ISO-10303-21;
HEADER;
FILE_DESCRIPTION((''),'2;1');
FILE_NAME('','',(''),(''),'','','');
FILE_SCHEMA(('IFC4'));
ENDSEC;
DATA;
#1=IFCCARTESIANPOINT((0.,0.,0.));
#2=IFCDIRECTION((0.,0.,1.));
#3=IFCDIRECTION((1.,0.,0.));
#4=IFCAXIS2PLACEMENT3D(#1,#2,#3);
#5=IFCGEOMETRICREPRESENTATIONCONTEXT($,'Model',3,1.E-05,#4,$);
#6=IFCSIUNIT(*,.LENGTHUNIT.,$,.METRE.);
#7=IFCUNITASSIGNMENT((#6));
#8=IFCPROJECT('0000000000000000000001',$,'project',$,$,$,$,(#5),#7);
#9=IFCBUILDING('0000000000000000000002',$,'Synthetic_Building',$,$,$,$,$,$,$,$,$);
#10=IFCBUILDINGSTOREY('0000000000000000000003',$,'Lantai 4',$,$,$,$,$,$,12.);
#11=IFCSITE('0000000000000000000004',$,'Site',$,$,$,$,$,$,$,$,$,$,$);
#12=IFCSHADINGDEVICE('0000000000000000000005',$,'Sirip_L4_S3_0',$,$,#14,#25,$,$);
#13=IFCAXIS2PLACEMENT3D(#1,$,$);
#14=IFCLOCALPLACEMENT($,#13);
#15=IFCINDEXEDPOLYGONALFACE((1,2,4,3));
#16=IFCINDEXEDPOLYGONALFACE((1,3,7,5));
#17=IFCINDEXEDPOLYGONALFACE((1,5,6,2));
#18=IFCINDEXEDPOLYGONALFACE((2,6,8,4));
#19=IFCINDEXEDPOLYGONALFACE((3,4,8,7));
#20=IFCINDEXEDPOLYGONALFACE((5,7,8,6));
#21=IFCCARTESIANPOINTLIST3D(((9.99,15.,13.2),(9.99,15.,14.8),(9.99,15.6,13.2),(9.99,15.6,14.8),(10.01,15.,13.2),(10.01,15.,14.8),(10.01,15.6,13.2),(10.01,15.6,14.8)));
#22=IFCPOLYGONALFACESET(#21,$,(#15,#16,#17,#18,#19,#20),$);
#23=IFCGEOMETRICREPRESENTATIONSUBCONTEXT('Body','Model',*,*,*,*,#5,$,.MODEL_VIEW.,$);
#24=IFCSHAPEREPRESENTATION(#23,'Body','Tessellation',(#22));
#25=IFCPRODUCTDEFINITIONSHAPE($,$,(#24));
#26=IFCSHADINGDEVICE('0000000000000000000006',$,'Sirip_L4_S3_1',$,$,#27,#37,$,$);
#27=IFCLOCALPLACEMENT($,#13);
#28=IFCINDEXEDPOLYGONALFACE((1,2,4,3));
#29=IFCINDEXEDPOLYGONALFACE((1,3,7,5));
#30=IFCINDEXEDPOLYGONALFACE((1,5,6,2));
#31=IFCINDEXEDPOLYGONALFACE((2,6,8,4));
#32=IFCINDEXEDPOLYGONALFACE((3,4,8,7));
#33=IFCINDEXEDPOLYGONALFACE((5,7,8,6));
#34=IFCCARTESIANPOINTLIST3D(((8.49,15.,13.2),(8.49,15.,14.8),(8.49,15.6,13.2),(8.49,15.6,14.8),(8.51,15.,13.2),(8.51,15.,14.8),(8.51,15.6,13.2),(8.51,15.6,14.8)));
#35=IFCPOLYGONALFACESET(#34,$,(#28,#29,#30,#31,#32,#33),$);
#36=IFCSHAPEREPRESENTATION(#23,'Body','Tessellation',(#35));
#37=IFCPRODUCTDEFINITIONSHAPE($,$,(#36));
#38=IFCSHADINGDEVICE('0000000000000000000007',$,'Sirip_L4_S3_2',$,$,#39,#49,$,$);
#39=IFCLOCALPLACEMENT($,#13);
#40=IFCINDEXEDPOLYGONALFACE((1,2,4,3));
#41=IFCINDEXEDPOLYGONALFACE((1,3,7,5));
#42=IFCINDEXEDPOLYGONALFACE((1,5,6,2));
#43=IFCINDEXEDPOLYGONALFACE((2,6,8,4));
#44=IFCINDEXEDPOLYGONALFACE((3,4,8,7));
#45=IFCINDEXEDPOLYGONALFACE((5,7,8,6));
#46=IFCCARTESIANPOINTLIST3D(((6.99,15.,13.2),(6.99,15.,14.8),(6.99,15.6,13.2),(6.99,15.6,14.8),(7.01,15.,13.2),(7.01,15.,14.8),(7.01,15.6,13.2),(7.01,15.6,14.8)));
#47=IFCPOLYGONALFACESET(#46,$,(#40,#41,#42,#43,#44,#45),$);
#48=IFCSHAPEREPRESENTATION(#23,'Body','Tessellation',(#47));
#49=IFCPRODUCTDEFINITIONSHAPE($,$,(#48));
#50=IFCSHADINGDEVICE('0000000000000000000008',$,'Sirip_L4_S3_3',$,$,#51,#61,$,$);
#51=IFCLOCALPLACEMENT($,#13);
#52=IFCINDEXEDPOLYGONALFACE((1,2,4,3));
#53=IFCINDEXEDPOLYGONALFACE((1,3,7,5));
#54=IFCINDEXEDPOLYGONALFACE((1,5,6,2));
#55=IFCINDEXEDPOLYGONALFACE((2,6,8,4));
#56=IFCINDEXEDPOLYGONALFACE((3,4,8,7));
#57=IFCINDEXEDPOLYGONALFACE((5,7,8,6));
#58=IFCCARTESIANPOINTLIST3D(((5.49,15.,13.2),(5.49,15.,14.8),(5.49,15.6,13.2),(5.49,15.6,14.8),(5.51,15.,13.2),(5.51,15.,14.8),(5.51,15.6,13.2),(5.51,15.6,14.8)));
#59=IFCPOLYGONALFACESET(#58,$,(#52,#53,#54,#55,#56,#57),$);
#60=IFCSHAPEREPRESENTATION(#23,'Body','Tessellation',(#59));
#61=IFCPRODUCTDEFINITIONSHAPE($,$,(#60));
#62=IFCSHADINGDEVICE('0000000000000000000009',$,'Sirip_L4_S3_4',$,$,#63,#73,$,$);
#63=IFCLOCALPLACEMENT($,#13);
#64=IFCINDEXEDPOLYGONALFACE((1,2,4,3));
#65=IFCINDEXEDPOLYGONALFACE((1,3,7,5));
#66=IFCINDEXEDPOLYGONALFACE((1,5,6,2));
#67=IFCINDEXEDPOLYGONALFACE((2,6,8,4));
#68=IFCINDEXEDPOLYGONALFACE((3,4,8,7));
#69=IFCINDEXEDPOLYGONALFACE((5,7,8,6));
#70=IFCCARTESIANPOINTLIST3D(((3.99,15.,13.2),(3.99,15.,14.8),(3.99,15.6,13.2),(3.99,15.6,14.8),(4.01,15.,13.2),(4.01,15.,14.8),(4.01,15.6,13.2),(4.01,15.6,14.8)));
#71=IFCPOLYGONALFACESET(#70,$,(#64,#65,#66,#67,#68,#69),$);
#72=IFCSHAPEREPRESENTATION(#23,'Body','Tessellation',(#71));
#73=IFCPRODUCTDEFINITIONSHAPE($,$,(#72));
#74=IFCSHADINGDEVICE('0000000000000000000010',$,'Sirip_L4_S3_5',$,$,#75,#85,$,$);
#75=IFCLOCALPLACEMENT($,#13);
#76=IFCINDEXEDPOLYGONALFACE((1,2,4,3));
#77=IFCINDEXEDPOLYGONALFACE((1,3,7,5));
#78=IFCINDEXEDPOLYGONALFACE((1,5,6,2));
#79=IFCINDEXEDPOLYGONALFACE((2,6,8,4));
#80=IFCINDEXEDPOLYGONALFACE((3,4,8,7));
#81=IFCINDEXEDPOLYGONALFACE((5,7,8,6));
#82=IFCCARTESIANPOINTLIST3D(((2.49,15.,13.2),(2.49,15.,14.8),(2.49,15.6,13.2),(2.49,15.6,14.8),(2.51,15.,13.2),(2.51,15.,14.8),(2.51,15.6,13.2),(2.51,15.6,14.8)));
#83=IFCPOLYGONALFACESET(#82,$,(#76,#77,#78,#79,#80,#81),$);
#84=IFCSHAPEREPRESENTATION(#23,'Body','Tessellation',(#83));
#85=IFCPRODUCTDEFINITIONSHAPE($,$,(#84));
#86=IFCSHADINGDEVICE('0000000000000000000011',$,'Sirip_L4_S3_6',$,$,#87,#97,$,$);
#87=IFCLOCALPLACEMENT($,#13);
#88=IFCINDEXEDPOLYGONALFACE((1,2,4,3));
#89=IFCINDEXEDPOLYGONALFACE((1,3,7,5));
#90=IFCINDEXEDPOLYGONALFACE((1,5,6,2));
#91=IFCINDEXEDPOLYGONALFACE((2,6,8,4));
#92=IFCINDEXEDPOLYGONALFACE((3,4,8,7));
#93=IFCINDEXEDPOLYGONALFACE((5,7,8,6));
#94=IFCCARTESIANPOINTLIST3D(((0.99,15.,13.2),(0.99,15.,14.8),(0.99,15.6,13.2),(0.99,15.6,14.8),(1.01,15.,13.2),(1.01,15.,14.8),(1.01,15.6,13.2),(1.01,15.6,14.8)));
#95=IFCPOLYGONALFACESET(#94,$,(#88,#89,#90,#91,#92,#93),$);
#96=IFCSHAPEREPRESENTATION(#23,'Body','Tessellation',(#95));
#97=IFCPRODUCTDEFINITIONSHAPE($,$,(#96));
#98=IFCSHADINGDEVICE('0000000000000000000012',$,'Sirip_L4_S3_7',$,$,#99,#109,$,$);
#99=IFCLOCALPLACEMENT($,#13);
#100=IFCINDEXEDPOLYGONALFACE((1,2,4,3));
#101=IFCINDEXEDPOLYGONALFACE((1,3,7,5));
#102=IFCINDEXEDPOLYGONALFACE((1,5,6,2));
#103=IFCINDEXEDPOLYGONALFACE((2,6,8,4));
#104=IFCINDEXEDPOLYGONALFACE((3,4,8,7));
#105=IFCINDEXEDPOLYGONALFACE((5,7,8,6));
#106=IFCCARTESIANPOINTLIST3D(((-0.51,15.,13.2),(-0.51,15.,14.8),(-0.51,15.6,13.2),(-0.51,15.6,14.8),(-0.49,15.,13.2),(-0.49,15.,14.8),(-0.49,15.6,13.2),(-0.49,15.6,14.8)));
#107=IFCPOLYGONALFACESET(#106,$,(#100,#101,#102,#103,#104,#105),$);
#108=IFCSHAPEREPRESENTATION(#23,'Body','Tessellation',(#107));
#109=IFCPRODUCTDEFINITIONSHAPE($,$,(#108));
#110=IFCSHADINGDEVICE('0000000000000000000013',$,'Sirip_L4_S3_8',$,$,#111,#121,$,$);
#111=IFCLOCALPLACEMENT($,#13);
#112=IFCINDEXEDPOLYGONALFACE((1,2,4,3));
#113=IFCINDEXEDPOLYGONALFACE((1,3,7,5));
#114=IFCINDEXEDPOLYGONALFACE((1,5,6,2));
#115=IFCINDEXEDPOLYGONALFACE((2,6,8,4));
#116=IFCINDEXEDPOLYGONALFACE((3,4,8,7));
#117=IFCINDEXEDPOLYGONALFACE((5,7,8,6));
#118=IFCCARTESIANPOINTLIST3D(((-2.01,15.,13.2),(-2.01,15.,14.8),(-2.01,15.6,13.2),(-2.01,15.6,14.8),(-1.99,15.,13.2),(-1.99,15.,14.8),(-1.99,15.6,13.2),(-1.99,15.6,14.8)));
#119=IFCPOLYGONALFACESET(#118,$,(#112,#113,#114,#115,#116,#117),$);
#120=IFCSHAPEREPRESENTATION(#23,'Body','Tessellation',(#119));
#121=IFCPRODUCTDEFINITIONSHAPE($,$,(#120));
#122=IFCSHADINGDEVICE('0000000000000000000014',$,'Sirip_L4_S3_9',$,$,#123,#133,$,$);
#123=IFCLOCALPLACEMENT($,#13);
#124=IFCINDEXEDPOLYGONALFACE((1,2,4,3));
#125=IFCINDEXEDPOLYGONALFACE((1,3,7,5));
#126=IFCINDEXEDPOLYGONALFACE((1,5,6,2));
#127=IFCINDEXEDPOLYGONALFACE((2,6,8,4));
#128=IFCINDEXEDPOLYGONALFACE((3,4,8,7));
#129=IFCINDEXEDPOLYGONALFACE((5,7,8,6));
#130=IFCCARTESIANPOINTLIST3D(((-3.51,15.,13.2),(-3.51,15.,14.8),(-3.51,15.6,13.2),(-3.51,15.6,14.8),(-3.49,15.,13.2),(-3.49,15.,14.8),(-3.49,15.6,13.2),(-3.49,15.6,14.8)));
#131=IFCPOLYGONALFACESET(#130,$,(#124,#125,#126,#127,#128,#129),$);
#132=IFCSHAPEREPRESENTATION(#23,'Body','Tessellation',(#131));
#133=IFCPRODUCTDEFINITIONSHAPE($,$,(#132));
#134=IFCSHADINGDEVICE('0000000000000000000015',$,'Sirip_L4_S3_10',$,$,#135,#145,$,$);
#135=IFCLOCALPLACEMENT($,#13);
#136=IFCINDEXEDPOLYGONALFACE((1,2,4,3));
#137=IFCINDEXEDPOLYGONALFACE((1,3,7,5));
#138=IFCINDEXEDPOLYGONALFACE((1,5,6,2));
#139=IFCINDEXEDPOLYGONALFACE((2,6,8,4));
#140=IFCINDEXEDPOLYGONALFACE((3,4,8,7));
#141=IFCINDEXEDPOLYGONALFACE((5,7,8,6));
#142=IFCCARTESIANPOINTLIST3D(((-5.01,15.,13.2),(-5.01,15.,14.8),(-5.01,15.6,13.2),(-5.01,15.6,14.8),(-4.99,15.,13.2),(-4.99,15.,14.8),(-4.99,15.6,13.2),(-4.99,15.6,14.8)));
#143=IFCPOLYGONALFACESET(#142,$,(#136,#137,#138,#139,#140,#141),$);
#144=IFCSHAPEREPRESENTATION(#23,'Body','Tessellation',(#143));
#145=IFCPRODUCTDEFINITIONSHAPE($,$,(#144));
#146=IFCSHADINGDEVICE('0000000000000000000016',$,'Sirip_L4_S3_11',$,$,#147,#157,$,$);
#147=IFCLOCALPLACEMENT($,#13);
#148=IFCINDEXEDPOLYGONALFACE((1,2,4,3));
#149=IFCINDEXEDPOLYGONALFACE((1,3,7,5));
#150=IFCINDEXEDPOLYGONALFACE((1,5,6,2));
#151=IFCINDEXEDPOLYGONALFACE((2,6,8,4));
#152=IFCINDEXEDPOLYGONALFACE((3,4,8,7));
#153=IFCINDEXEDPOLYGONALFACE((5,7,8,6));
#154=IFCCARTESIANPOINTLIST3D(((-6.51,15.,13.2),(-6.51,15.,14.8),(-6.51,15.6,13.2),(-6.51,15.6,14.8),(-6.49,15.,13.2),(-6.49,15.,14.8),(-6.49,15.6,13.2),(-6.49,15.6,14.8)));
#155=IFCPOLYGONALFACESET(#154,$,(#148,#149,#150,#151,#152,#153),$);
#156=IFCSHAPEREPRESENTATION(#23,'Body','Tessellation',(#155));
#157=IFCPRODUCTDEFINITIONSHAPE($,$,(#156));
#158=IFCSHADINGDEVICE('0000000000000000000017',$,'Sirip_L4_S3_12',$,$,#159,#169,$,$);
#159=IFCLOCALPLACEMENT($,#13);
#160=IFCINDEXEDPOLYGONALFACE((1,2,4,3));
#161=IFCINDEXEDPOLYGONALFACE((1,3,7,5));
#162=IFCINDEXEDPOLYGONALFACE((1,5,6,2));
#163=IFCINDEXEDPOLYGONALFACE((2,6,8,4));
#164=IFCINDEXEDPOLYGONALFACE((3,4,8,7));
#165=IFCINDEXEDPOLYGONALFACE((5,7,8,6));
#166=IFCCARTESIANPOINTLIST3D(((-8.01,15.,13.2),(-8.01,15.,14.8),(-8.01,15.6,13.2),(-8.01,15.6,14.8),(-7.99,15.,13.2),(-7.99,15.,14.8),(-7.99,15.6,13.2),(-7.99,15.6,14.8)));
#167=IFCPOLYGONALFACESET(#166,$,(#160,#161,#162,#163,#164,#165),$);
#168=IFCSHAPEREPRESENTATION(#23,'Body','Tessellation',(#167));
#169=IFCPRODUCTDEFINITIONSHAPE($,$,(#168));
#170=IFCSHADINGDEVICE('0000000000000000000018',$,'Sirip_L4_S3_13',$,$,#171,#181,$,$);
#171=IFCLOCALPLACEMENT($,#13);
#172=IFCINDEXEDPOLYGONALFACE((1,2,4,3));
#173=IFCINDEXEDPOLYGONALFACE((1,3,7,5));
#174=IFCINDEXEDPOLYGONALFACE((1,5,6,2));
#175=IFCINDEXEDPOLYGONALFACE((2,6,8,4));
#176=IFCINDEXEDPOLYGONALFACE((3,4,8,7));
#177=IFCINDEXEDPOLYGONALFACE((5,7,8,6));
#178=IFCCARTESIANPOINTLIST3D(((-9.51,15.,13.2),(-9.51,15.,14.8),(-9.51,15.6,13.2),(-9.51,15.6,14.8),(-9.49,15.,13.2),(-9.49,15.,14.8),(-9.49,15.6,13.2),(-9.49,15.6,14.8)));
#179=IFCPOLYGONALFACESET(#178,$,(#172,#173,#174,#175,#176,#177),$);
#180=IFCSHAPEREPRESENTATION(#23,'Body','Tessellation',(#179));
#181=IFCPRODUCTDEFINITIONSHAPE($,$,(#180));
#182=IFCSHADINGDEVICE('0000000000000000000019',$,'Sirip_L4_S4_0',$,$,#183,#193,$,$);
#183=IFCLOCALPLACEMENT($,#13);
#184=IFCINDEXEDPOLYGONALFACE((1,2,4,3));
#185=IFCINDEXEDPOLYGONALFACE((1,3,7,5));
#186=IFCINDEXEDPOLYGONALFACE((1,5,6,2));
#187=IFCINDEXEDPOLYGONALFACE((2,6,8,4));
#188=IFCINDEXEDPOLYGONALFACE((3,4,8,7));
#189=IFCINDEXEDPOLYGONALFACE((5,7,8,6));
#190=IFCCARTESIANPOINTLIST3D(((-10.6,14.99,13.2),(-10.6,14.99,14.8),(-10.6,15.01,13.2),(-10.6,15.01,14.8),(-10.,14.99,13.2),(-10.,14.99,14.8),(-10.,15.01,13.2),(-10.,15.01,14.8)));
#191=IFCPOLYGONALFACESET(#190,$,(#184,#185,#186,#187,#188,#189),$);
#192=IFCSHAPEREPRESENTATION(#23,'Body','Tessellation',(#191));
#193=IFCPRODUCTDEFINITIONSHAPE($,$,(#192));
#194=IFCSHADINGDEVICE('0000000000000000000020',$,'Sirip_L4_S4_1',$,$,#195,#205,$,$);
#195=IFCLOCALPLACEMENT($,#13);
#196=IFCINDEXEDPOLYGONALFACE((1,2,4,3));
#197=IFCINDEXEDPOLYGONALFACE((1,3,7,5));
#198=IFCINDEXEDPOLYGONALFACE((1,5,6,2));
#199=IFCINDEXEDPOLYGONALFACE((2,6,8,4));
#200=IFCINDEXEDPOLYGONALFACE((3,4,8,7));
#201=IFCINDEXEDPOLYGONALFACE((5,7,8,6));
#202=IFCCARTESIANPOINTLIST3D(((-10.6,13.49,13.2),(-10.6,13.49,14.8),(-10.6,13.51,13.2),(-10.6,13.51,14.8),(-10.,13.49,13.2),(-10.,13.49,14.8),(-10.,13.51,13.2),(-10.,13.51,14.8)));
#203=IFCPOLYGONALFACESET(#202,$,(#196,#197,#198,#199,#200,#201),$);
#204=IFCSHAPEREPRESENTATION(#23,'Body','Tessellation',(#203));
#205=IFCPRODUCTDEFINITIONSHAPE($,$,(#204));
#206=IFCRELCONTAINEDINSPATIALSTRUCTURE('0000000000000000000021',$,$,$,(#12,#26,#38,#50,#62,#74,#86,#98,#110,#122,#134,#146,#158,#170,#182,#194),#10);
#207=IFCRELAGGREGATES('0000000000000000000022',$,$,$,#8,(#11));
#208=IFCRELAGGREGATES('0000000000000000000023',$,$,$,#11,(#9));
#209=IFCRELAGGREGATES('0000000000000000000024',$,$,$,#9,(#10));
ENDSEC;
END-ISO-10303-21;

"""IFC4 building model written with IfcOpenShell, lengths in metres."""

from ifc_helpers import new_model, si_unit, frame, origin_with_axes, place, context, subcontext, project, spatial, polyline, outline, extrude, element, save


model = new_model("IFC4")

# Units and contexts
model_context = context("Model", 3, precision=1e-05, world=origin_with_axes())
body_context = subcontext(model_context, "Body", "Model", "MODEL_VIEW")
ifc_project = project(units=[si_unit("LENGTHUNIT", "METRE")], contexts=[model_context])

# Site, building, storey
site = spatial("IfcSite", under=ifc_project, Name="Site")
building = spatial("IfcBuilding", under=site, Name="Synthetic_Building")
storey = spatial("IfcBuildingStorey", under=building, Name="Lantai 4", Elevation=12.0)

# Shading devices
shading_device_1_placement = place(None, origin_with_axes())
element("IfcShadingDevice", 1, at=shading_device_1_placement, inside=storey, Name="Sirip_L4_S3_0", context=body_context, shape_type="SweptSolid", body=[
    extrude(outline(polyline([(10.01, 15.0), (9.99, 15.0), (9.99, 15.6), (10.01, 15.6), (10.01, 15.0)])), frame((0.0, 0.0, 13.2), z_axis=(0.0, 0.0, 1.0), x_axis=(1.0, 0.0, 0.0)), (0.0, 0.0, 1.0), 1.6),
])
shading_device_2_placement = place(None, origin_with_axes())
element("IfcShadingDevice", 2, at=shading_device_2_placement, inside=storey, Name="Sirip_L4_S3_1", context=body_context, shape_type="SweptSolid", body=[
    extrude(outline(polyline([(8.51, 15.0), (8.49, 15.0), (8.49, 15.6), (8.51, 15.6), (8.51, 15.0)])), frame((0.0, 0.0, 13.2), z_axis=(0.0, 0.0, 1.0), x_axis=(1.0, 0.0, 0.0)), (0.0, 0.0, 1.0), 1.6),
])
shading_device_3_placement = place(None, origin_with_axes())
element("IfcShadingDevice", 3, at=shading_device_3_placement, inside=storey, Name="Sirip_L4_S3_2", context=body_context, shape_type="SweptSolid", body=[
    extrude(outline(polyline([(7.01, 15.0), (6.99, 15.0), (6.99, 15.6), (7.01, 15.6), (7.01, 15.0)])), frame((0.0, 0.0, 13.2), z_axis=(0.0, 0.0, 1.0), x_axis=(1.0, 0.0, 0.0)), (0.0, 0.0, 1.0), 1.6),
])
shading_device_4_placement = place(None, origin_with_axes())
element("IfcShadingDevice", 4, at=shading_device_4_placement, inside=storey, Name="Sirip_L4_S3_3", context=body_context, shape_type="SweptSolid", body=[
    extrude(outline(polyline([(5.51, 15.0), (5.49, 15.0), (5.49, 15.6), (5.51, 15.6), (5.51, 15.0)])), frame((0.0, 0.0, 13.2), z_axis=(0.0, 0.0, 1.0), x_axis=(1.0, 0.0, 0.0)), (0.0, 0.0, 1.0), 1.6),
])
shading_device_5_placement = place(None, origin_with_axes())
element("IfcShadingDevice", 5, at=shading_device_5_placement, inside=storey, Name="Sirip_L4_S3_4", context=body_context, shape_type="SweptSolid", body=[
    extrude(outline(polyline([(4.01, 15.0), (3.99, 15.0), (3.99, 15.6), (4.01, 15.6), (4.01, 15.0)])), frame((0.0, 0.0, 13.2), z_axis=(0.0, 0.0, 1.0), x_axis=(1.0, 0.0, 0.0)), (0.0, 0.0, 1.0), 1.6),
])
shading_device_6_placement = place(None, origin_with_axes())
element("IfcShadingDevice", 6, at=shading_device_6_placement, inside=storey, Name="Sirip_L4_S3_5", context=body_context, shape_type="SweptSolid", body=[
    extrude(outline(polyline([(2.51, 15.0), (2.49, 15.0), (2.49, 15.6), (2.51, 15.6), (2.51, 15.0)])), frame((0.0, 0.0, 13.2), z_axis=(0.0, 0.0, 1.0), x_axis=(1.0, 0.0, 0.0)), (0.0, 0.0, 1.0), 1.6),
])
shading_device_7_placement = place(None, origin_with_axes())
element("IfcShadingDevice", 7, at=shading_device_7_placement, inside=storey, Name="Sirip_L4_S3_6", context=body_context, shape_type="SweptSolid", body=[
    extrude(outline(polyline([(1.01, 15.0), (0.99, 15.0), (0.99, 15.6), (1.01, 15.6), (1.01, 15.0)])), frame((0.0, 0.0, 13.2), z_axis=(0.0, 0.0, 1.0), x_axis=(1.0, 0.0, 0.0)), (0.0, 0.0, 1.0), 1.6),
])
shading_device_8_placement = place(None, origin_with_axes())
element("IfcShadingDevice", 8, at=shading_device_8_placement, inside=storey, Name="Sirip_L4_S3_7", context=body_context, shape_type="SweptSolid", body=[
    extrude(outline(polyline([(-0.49, 15.0), (-0.51, 15.0), (-0.51, 15.6), (-0.49, 15.6), (-0.49, 15.0)])), frame((0.0, 0.0, 13.2), z_axis=(0.0, 0.0, 1.0), x_axis=(1.0, 0.0, 0.0)), (0.0, 0.0, 1.0), 1.6),
])
shading_device_9_placement = place(None, origin_with_axes())
element("IfcShadingDevice", 9, at=shading_device_9_placement, inside=storey, Name="Sirip_L4_S3_8", context=body_context, shape_type="SweptSolid", body=[
    extrude(outline(polyline([(-1.99, 15.0), (-2.01, 15.0), (-2.01, 15.6), (-1.99, 15.6), (-1.99, 15.0)])), frame((0.0, 0.0, 13.2), z_axis=(0.0, 0.0, 1.0), x_axis=(1.0, 0.0, 0.0)), (0.0, 0.0, 1.0), 1.6),
])
shading_device_10_placement = place(None, origin_with_axes())
element("IfcShadingDevice", 10, at=shading_device_10_placement, inside=storey, Name="Sirip_L4_S3_9", context=body_context, shape_type="SweptSolid", body=[
    extrude(outline(polyline([(-3.49, 15.0), (-3.51, 15.0), (-3.51, 15.6), (-3.49, 15.6), (-3.49, 15.0)])), frame((0.0, 0.0, 13.2), z_axis=(0.0, 0.0, 1.0), x_axis=(1.0, 0.0, 0.0)), (0.0, 0.0, 1.0), 1.6),
])
shading_device_11_placement = place(None, origin_with_axes())
element("IfcShadingDevice", 11, at=shading_device_11_placement, inside=storey, Name="Sirip_L4_S3_10", context=body_context, shape_type="SweptSolid", body=[
    extrude(outline(polyline([(-4.99, 15.0), (-5.01, 15.0), (-5.01, 15.6), (-4.99, 15.6), (-4.99, 15.0)])), frame((0.0, 0.0, 13.2), z_axis=(0.0, 0.0, 1.0), x_axis=(1.0, 0.0, 0.0)), (0.0, 0.0, 1.0), 1.6),
])
shading_device_12_placement = place(None, origin_with_axes())
element("IfcShadingDevice", 12, at=shading_device_12_placement, inside=storey, Name="Sirip_L4_S3_11", context=body_context, shape_type="SweptSolid", body=[
    extrude(outline(polyline([(-6.49, 15.0), (-6.51, 15.0), (-6.51, 15.6), (-6.49, 15.6), (-6.49, 15.0)])), frame((0.0, 0.0, 13.2), z_axis=(0.0, 0.0, 1.0), x_axis=(1.0, 0.0, 0.0)), (0.0, 0.0, 1.0), 1.6),
])
shading_device_13_placement = place(None, origin_with_axes())
element("IfcShadingDevice", 13, at=shading_device_13_placement, inside=storey, Name="Sirip_L4_S3_12", context=body_context, shape_type="SweptSolid", body=[
    extrude(outline(polyline([(-7.99, 15.0), (-8.01, 15.0), (-8.01, 15.6), (-7.99, 15.6), (-7.99, 15.0)])), frame((0.0, 0.0, 13.2), z_axis=(0.0, 0.0, 1.0), x_axis=(1.0, 0.0, 0.0)), (0.0, 0.0, 1.0), 1.6),
])
shading_device_14_placement = place(None, origin_with_axes())
element("IfcShadingDevice", 14, at=shading_device_14_placement, inside=storey, Name="Sirip_L4_S3_13", context=body_context, shape_type="SweptSolid", body=[
    extrude(outline(polyline([(-9.49, 15.0), (-9.51, 15.0), (-9.51, 15.6), (-9.49, 15.6), (-9.49, 15.0)])), frame((0.0, 0.0, 13.2), z_axis=(0.0, 0.0, 1.0), x_axis=(1.0, 0.0, 0.0)), (0.0, 0.0, 1.0), 1.6),
])
shading_device_15_placement = place(None, origin_with_axes())
element("IfcShadingDevice", 15, at=shading_device_15_placement, inside=storey, Name="Sirip_L4_S4_0", context=body_context, shape_type="SweptSolid", body=[
    extrude(outline(polyline([(-10.0, 15.01), (-10.0, 14.99), (-10.6, 14.99), (-10.6, 15.01), (-10.0, 15.01)])), frame((0.0, 0.0, 13.2), z_axis=(0.0, 0.0, 1.0), x_axis=(1.0, 0.0, 0.0)), (0.0, 0.0, 1.0), 1.6),
])
shading_device_16_placement = place(None, origin_with_axes())
element("IfcShadingDevice", 16, at=shading_device_16_placement, inside=storey, Name="Sirip_L4_S4_1", context=body_context, shape_type="SweptSolid", body=[
    extrude(outline(polyline([(-10.0, 13.51), (-10.0, 13.49), (-10.6, 13.49), (-10.6, 13.51), (-10.0, 13.51)])), frame((0.0, 0.0, 13.2), z_axis=(0.0, 0.0, 1.0), x_axis=(1.0, 0.0, 0.0)), (0.0, 0.0, 1.0), 1.6),
])

save(model, "model.ifc")
